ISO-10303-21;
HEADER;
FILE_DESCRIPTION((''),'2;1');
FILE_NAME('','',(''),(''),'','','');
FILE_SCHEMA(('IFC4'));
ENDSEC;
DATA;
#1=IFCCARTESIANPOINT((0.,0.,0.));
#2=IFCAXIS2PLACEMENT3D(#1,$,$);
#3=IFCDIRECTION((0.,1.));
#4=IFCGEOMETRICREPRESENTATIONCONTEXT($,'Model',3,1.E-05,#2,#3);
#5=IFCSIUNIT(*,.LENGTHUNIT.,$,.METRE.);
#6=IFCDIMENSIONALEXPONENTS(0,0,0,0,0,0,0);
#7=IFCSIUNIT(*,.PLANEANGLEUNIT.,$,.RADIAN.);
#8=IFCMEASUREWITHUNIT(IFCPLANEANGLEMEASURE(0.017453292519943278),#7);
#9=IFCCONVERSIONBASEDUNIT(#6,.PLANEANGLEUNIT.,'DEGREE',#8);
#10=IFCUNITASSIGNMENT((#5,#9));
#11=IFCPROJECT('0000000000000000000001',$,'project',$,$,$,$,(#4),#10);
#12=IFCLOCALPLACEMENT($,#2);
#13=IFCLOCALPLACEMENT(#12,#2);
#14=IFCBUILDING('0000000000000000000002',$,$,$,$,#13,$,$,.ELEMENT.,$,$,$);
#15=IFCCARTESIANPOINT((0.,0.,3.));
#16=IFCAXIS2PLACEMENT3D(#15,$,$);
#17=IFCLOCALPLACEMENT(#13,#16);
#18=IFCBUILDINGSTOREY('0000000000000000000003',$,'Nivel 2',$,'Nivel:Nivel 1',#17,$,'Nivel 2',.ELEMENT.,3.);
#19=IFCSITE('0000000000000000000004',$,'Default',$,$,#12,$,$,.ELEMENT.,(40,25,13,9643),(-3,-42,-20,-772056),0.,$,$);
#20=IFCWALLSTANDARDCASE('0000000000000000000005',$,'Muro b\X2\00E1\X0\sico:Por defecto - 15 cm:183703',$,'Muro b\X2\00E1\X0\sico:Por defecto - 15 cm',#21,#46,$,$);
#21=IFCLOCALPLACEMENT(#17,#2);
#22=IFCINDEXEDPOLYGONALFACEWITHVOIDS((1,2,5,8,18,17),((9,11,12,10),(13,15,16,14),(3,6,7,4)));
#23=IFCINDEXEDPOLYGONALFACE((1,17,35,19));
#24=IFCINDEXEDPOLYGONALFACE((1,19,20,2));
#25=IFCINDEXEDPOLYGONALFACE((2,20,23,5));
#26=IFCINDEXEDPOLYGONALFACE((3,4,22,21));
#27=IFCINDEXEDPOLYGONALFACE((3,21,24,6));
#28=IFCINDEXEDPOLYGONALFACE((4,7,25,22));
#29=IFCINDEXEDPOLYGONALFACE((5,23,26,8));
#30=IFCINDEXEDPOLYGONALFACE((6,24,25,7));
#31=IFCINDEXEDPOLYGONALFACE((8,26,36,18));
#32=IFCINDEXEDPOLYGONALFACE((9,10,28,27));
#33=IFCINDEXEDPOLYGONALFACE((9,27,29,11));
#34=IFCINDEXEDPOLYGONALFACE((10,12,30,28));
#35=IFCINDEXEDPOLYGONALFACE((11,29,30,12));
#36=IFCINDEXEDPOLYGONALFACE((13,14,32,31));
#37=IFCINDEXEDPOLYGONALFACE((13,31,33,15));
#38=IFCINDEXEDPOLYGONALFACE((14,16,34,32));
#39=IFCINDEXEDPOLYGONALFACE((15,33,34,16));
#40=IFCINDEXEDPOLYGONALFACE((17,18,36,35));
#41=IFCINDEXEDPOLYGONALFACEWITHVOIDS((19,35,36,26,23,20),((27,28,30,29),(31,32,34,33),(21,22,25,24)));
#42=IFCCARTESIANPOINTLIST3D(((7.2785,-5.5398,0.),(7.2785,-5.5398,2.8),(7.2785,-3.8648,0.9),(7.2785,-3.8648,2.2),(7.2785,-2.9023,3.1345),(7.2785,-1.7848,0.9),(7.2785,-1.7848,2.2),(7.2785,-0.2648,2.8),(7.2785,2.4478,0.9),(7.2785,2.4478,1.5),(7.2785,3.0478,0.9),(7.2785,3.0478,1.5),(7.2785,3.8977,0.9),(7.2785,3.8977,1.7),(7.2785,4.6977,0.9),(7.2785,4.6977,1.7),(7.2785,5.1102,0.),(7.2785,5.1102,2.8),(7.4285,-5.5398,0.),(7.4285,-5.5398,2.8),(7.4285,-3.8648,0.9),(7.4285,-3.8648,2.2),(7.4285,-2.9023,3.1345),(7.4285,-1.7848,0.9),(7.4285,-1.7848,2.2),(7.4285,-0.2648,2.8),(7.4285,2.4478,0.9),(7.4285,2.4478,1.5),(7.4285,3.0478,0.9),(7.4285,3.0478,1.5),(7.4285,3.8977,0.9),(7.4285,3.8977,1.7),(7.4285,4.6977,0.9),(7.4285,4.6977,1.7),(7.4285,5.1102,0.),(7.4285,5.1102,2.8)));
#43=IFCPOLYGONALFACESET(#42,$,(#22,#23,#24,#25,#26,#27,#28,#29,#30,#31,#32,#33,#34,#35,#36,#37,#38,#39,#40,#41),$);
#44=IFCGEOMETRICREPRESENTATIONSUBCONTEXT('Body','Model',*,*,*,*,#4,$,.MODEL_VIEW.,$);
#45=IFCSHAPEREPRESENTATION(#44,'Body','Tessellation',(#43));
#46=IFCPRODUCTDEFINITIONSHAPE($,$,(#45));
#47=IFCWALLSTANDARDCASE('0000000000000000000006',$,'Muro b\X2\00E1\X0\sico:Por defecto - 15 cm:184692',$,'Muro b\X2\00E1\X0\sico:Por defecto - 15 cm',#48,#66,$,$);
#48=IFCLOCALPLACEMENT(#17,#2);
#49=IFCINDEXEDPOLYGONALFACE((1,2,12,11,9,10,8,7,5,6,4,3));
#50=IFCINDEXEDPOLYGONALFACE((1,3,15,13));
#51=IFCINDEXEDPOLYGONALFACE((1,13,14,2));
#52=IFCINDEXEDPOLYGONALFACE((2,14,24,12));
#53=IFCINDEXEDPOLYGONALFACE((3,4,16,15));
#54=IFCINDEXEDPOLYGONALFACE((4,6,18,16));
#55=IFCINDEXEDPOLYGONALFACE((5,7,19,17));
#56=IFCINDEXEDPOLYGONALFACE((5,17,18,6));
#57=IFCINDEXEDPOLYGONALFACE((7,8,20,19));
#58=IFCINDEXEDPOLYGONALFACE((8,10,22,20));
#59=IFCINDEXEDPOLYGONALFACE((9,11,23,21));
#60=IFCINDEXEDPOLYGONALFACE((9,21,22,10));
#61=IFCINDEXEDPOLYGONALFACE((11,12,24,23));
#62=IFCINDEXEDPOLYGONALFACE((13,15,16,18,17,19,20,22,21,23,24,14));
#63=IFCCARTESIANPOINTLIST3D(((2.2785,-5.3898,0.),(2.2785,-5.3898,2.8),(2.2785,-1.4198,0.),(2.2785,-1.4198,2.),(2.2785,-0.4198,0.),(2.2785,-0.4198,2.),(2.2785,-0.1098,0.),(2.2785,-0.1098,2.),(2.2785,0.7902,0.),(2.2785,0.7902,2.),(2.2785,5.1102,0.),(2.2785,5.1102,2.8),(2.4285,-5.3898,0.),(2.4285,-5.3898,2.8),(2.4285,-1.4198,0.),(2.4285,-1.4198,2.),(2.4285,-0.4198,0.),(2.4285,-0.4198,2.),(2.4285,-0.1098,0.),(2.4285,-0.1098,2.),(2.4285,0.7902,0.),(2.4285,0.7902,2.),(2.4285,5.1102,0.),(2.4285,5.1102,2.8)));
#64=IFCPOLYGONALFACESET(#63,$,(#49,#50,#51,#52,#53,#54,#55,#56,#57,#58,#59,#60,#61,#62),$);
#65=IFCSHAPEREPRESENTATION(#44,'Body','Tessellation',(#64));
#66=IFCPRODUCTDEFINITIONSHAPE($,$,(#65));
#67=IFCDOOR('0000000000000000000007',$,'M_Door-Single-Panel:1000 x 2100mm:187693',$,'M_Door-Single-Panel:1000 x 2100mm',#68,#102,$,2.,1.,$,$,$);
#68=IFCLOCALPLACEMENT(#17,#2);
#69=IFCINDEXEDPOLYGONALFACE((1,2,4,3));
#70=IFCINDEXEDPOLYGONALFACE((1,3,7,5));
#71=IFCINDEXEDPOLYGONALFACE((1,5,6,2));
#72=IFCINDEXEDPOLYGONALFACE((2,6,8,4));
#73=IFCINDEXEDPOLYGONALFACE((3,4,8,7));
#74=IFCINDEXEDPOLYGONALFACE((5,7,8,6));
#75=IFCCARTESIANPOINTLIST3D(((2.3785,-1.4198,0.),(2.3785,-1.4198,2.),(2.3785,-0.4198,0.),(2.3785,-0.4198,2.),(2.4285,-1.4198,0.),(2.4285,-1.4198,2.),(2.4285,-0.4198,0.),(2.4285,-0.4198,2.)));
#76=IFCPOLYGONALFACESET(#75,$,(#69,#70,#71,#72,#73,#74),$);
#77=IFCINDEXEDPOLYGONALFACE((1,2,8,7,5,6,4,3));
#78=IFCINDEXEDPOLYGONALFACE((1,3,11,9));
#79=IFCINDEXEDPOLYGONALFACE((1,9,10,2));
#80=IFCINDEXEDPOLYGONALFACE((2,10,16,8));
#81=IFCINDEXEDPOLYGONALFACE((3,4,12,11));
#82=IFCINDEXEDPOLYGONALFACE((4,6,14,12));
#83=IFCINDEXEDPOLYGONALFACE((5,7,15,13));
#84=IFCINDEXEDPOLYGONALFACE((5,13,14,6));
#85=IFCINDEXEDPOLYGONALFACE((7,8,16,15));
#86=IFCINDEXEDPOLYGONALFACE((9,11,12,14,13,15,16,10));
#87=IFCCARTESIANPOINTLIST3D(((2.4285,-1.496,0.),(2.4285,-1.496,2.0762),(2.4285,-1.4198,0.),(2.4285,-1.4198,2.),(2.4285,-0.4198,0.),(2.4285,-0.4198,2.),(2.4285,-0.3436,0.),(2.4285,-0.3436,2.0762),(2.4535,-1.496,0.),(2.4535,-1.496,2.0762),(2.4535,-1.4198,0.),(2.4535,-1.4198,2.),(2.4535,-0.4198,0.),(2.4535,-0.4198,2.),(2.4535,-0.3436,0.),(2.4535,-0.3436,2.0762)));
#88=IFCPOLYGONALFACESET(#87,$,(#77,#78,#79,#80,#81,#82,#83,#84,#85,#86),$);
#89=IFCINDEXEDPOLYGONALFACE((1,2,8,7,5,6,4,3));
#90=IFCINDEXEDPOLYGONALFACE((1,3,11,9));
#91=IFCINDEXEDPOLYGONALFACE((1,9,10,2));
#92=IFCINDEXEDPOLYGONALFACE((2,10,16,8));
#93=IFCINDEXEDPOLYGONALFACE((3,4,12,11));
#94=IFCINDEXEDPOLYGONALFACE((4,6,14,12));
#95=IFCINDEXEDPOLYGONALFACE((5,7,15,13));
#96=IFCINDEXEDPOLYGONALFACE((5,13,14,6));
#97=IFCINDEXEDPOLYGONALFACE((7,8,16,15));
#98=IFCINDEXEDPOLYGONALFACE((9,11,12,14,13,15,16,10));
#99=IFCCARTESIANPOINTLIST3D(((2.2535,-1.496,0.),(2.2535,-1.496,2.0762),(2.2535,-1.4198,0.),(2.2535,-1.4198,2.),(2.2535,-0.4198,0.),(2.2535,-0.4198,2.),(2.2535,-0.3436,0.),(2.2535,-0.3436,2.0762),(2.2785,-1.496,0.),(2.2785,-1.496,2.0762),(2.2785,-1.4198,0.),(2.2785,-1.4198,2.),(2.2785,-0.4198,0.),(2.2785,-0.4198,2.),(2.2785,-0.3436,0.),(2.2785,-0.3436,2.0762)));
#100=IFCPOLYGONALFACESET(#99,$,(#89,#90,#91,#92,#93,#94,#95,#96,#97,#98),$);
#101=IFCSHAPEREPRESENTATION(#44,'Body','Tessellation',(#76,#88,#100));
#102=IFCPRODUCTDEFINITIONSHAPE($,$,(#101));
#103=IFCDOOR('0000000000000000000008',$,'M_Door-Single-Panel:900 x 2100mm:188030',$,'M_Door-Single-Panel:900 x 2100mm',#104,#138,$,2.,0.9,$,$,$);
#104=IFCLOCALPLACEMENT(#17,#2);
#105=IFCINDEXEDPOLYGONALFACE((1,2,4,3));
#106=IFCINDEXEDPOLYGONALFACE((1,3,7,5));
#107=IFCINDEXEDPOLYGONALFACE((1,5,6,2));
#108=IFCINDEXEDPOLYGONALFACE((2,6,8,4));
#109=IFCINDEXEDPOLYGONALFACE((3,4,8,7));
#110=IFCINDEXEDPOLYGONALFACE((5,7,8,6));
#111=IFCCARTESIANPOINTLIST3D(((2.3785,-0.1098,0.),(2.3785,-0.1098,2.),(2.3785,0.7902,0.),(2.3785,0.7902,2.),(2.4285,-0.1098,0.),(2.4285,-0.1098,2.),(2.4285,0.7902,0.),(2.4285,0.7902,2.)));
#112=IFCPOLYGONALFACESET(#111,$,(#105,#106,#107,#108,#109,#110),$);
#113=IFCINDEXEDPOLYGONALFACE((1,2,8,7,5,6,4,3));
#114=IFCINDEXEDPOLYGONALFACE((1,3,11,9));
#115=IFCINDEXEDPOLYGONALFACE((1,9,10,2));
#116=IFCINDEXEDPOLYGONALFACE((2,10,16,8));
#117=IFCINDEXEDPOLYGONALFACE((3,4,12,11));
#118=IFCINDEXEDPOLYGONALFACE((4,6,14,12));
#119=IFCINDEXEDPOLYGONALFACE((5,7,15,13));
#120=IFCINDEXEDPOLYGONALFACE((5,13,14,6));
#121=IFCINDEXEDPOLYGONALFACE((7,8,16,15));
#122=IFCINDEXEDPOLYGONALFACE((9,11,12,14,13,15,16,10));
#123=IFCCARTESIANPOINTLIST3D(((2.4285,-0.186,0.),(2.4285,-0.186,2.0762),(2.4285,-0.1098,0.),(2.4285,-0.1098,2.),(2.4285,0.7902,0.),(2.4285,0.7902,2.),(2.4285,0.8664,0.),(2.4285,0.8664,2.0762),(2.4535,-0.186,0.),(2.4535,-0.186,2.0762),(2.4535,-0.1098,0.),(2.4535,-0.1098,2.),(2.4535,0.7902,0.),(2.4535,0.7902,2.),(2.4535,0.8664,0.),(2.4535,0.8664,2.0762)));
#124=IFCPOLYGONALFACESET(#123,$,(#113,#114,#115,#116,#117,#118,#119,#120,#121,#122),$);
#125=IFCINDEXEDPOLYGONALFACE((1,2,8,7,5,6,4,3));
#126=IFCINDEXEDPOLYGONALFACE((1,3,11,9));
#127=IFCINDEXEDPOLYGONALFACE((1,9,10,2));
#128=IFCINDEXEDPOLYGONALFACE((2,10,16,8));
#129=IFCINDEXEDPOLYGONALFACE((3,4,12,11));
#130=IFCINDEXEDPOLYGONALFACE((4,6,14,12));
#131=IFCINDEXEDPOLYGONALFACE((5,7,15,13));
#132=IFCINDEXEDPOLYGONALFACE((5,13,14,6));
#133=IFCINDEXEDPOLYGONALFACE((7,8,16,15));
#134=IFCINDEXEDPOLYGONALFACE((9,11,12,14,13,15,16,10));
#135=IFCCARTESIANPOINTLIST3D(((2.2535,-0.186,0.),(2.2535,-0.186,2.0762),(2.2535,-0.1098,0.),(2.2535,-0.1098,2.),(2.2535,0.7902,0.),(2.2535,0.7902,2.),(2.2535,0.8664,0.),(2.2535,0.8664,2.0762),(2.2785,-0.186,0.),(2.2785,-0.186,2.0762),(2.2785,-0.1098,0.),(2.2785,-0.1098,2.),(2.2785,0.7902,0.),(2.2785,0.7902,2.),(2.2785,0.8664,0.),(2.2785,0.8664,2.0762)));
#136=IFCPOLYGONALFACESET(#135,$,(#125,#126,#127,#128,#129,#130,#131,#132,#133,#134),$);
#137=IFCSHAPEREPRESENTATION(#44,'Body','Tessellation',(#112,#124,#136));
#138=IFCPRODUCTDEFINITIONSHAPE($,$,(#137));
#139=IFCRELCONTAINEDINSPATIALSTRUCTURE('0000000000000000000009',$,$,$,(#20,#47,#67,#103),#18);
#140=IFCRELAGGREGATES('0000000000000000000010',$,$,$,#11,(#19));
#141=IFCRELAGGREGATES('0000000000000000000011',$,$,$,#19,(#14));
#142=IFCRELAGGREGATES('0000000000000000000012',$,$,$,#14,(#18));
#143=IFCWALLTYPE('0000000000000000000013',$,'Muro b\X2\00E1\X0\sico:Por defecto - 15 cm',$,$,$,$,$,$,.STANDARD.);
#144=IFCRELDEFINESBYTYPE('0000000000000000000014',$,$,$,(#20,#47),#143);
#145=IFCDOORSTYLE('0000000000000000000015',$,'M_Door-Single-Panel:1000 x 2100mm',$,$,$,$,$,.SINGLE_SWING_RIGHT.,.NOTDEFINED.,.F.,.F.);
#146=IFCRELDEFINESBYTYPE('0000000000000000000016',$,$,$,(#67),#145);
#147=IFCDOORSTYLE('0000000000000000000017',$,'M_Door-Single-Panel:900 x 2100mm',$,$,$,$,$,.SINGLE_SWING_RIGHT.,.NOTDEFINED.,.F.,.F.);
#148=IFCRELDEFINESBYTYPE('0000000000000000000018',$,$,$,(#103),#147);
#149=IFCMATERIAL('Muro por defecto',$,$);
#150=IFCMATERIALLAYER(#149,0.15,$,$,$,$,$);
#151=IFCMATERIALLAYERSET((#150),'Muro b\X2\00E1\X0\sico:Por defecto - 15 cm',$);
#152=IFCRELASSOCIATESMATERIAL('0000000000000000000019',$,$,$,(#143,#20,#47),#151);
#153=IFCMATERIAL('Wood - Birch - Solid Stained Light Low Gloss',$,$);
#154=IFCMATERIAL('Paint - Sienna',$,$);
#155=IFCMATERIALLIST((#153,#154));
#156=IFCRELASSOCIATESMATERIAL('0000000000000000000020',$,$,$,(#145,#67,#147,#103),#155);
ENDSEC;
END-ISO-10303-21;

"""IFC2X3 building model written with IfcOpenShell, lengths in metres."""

from ifc_helpers import new_model, entity, si_unit, converted_unit, direction, frame, frame_2d, origin, origin_2d_with_axis, place, context, subcontext, project, spatial, polyline, rectangle, outline, extrude, clip, bounded_halfspace, source, transform, mapped, material, material_list, layer, layer_set, layer_usage, type_object, type_shapes, element, fill, save


model = new_model("IFC2X3")

# Units and contexts
model_context = context("Model", 3, precision=1e-05, world=origin(), true_north=direction((0.0, 1.0)))
body_context = subcontext(model_context, "Body", "Model", "MODEL_VIEW")
ifc_project = project(units=[si_unit("LENGTHUNIT", "METRE"), converted_unit("PLANEANGLEUNIT", "DEGREE", entity("IfcPlaneAngleMeasure", 0.017453292519943278), si_unit("PLANEANGLEUNIT", "RADIAN"), dimensions=[0, 0, 0, 0, 0, 0, 0])], contexts=[model_context])

# Site, building, storey
site_placement = place(None, origin())
site = spatial("IfcSite", under=ifc_project, at=site_placement, Name="Default", CompositionType="ELEMENT", RefLatitude=(40, 25, 13, 9643), RefLongitude=(-3, -42, -20, -772056), RefElevation=0.0)
building_placement = place(site_placement, origin())
building = spatial("IfcBuilding", under=site, at=building_placement, CompositionType="ELEMENT")
storey_placement = place(building_placement, frame((0.0, 0.0, 3.0)))
storey = spatial("IfcBuildingStorey", under=building, at=storey_placement, Name="Nivel 2", ObjectType="Nivel:Nivel 1", LongName="Nivel 2", CompositionType="ELEMENT", Elevation=3.0)

# Wall, openings
ifc_material_1 = material(Name="Muro por defecto")
ifc_layer_1 = layer(ifc_material_1, 0.15)
ifc_layer_set_1 = layer_set([ifc_layer_1], Name="Muro básico:Por defecto - 15 cm")
ifc_layer_usage_1 = layer_usage(ifc_layer_set_1, "AXIS2", "NEGATIVE", 0.075)
wall_type_1 = type_object("IfcWallType", Name="Muro básico:Por defecto - 15 cm", PredefinedType="STANDARD", material=ifc_layer_set_1)
wall_1_placement = place(storey_placement, frame((7.3535, 5.1102, 0.0), z_axis=(0.0, 0.0, 1.0), x_axis=(0.0, -1.0, 0.0)))
wall_1 = element("IfcWallStandardCase", 1, at=wall_1_placement, inside=storey, type_object=wall_type_1, material=ifc_layer_usage_1, Name="Muro básico:Por defecto - 15 cm:183703", ObjectType="Muro básico:Por defecto - 15 cm", context=body_context, shape_type="Clipping", body=[
    clip(clip(clip(clip(extrude(rectangle(XDim=10.65, YDim=0.15, at=frame_2d((5.325, 0.0), x_axis=(-1.0, 0.0))), origin(), (0.0, 0.0, 1.0), 3.1345), bounded_halfspace(frame((0.0, -0.075, 2.8), z_axis=(0.0, 0.0, -1.0), x_axis=(0.0, 1.0, 0.0)), True, frame((0.0, -0.075, 2.8)), polyline([(0.0, 0.0), (0.15, 0.0), (1.475, 0.0), (1.625, 0.0), (2.925, 0.0), (3.075, 0.0), (5.3, 0.0), (5.375, 0.0), (5.375, 0.15), (0.0, 0.15), (0.0, 0.0)]))), bounded_halfspace(frame((5.375, -0.075, 2.8), z_axis=(-0.125829, 0.0, 0.992052), x_axis=(0.0, -1.0, 0.0)), False, frame((5.375, -0.075, 2.8)), polyline([(0.0, 0.0), (2.6375, 0.0), (2.6375, 0.15), (0.0, 0.15), (0.0, 0.0)]))), bounded_halfspace(frame((8.0125, -0.075, 3.1345), z_axis=(0.125829, 0.0, 0.992052), x_axis=(0.0, 1.0, 0.0)), False, frame((8.0125, -0.075, 3.1345)), polyline([(0.0, 0.0), (2.6375, 0.0), (2.6375, 0.15), (0.0, 0.15), (0.0, 0.0)]))), bounded_halfspace(frame((0.0, -0.075, 2.8), z_axis=(0.0, 0.0, -1.0), x_axis=(0.0, 1.0, 0.0)), True, frame((0.0, -0.075, 2.8)), polyline([(0.0, 0.0), (0.15, 0.0), (1.475, 0.0), (1.625, 0.0), (2.925, 0.0), (3.075, 0.0), (5.3, 0.0), (5.375, 0.0), (5.375, 0.15), (0.0, 0.15), (0.0, 0.0)]))),
])
opening_1_placement = place(wall_1_placement, frame((0.4125, -0.075, 0.9)))
element("IfcOpeningElement", 2, at=opening_1_placement, cuts=wall_1, ObjectType="Opening", context=body_context, shape_type="SweptSolid", body=[
    extrude(rectangle(XDim=0.8, YDim=0.8, at=frame_2d((0.4, 0.4), x_axis=(1.0, 0.0))), frame((0.0, 0.0, 0.0), z_axis=(0.0, 1.0, 0.0), x_axis=(0.0, 0.0, 1.0)), (0.0, 0.0, 1.0), 0.15),
])
opening_2_placement = place(wall_1_placement, frame((2.0625, -0.075, 0.9)))
element("IfcOpeningElement", 3, at=opening_2_placement, cuts=wall_1, ObjectType="Opening", context=body_context, shape_type="SweptSolid", body=[
    extrude(rectangle(XDim=0.6, YDim=0.6, at=frame_2d((0.3, 0.3), x_axis=(1.0, 0.0))), frame((0.0, 0.0, 0.0), z_axis=(0.0, 1.0, 0.0), x_axis=(0.0, 0.0, 1.0)), (0.0, 0.0, 1.0), 0.15),
])
opening_3_placement = place(wall_1_placement, frame((6.895, -0.075, 0.9)))
element("IfcOpeningElement", 4, at=opening_3_placement, cuts=wall_1, ObjectType="Opening", context=body_context, shape_type="SweptSolid", body=[
    extrude(rectangle(XDim=1.3, YDim=2.08, at=frame_2d((0.65, 1.04), x_axis=(-1.0, 0.0))), frame((0.0, 0.0, 0.0), z_axis=(0.0, 1.0, 0.0), x_axis=(0.0, 0.0, 1.0)), (0.0, 0.0, 1.0), 0.15),
])

# Wall, openings, doors
ifc_layer_usage_2 = layer_usage(ifc_layer_set_1, "AXIS2", "POSITIVE", -0.075)
wall_2_placement = place(storey_placement, frame((2.3535, -5.3898, 0.0), z_axis=(0.0, 0.0, 1.0), x_axis=(0.0, 1.0, 0.0)))
wall_2 = element("IfcWallStandardCase", 5, at=wall_2_placement, inside=storey, type_object=wall_type_1, material=ifc_layer_usage_2, Name="Muro básico:Por defecto - 15 cm:184692", ObjectType="Muro básico:Por defecto - 15 cm", context=body_context, shape_type="Clipping", body=[
    clip(extrude(rectangle(XDim=10.5, YDim=0.15, at=frame_2d((5.25, 0.0), x_axis=(1.0, 0.0))), origin(), (0.0, 0.0, 1.0), 2.8), bounded_halfspace(frame((0.0, -0.075, 2.8), z_axis=(0.0, 0.0, -1.0), x_axis=(0.0, -1.0, 0.0)), True, frame((0.0, -0.075, 2.8)), polyline([(0.0, 0.0), (5.05, 0.0), (5.125, 0.0), (5.2, 0.0), (8.35, 0.0), (8.5, 0.0), (10.35, 0.0), (10.5, 0.0), (10.5, 0.15), (9.475, 0.15), (9.325, 0.15), (5.2, 0.15), (5.05, 0.15), (0.0, 0.15), (0.0, 0.0)]))),
])
opening_4_placement = place(wall_2_placement, origin())
element("IfcOpeningElement", 6, at=opening_4_placement, cuts=wall_2, ObjectType="Opening", context=body_context, shape_type="SweptSolid", body=[
    extrude(rectangle(XDim=2.0, YDim=0.15, at=frame_2d((0.0, 0.0), x_axis=(0.0, 1.0))), frame((8.425, -0.815, 1.0), z_axis=(0.0, 1.0, 0.0), x_axis=(-1.0, 0.0, 0.0)), (0.0, 0.0, 1.0), 0.7),
])
opening_5_placement = place(wall_2_placement, frame((4.97, 0.075, 0.0)))
opening_5 = element("IfcOpeningElement", 7, at=opening_5_placement, cuts=wall_2, ObjectType="Opening", context=body_context, shape_type="SweptSolid", body=[
    extrude(rectangle(XDim=1.0, YDim=2.0, at=frame_2d((1.0, 0.5), x_axis=(0.0, 1.0))), frame((0.0, 0.0, 0.0), z_axis=(0.0, -1.0, 0.0), x_axis=(0.0, 0.0, 1.0)), (0.0, 0.0, 1.0), 0.15),
])
opening_6_placement = place(wall_2_placement, frame((6.18, 0.075, 0.0)))
opening_6 = element("IfcOpeningElement", 8, at=opening_6_placement, cuts=wall_2, ObjectType="Opening", context=body_context, shape_type="SweptSolid", body=[
    extrude(rectangle(XDim=0.9, YDim=2.0, at=frame_2d((1.0, 0.45), x_axis=(0.0, 1.0))), frame((0.0, 0.0, 0.0), z_axis=(0.0, -1.0, 0.0), x_axis=(0.0, 0.0, 1.0)), (0.0, 0.0, 1.0), 0.15),
])
ifc_material_2 = material(Name="Wood - Birch - Solid Stained Light Low Gloss")
ifc_material_3 = material(Name="Paint - Sienna")
ifc_material_list_1 = material_list([ifc_material_2, ifc_material_3])
door_style_1 = type_object("IfcDoorStyle", Name="M_Door-Single-Panel:1000 x 2100mm", ConstructionType="NOTDEFINED", OperationType="SINGLE_SWING_RIGHT", ParameterTakesPrecedence=False, Sizeable=False, material=ifc_material_list_1)
shared_shape_1 = source(origin(), body_context, "Body", "SweptSolid", [
    extrude(rectangle(XDim=0.05, YDim=1.0, at=origin_2d_with_axis()), frame((0.5, 0.125, 0.0), z_axis=(0.0, 0.0, 1.0), x_axis=(0.0, 1.0, 0.0)), (0.0, 0.0, 1.0), 2.0),
    extrude(outline(polyline([(-0.5762, -1.0571), (0.5762, -1.0571), (0.5762, 1.0191), (0.5, 1.0191), (0.5, -0.981), (-0.5, -0.981), (-0.5, 1.0191), (-0.5762, 1.0191), (-0.5762, -1.0571)])), frame((0.5, 0.15, 1.0191), z_axis=(0.0, 1.0, 0.0), x_axis=(1.0, 0.0, 0.0)), (0.0, 0.0, 1.0), 0.025),
    extrude(outline(polyline([(-1.0571, -0.5762), (1.019, -0.5762), (1.019, -0.5), (-0.9809, -0.5), (-0.9809, 0.5), (1.019, 0.5), (1.019, 0.5762), (-1.0571, 0.5762), (-1.0571, -0.5762)])), frame((0.5, -0.025, 1.019), z_axis=(0.0, 1.0, 0.0), x_axis=(0.0, 0.0, -1.0)), (0.0, 0.0, 1.0), 0.025),
])
type_shapes(door_style_1, [shared_shape_1])
door_1_placement = place(opening_5_placement, frame((0.0, 0.0, 0.0), z_axis=(0.0, 0.0, 1.0), x_axis=(-1.0, 0.0, 0.0)))
door_1 = element("IfcDoor", 9, at=door_1_placement, inside=storey, type_object=door_style_1, material=ifc_material_list_1, Name="M_Door-Single-Panel:1000 x 2100mm:187693", ObjectType="M_Door-Single-Panel:1000 x 2100mm", OverallHeight=2.0, OverallWidth=1.0, context=body_context, shape_type="MappedRepresentation", body=[
    mapped(shared_shape_1, transform((0.0, 0.0, 0.0), scale=1.0)),
])
fill(opening_5, door_1)
door_style_2 = type_object("IfcDoorStyle", Name="M_Door-Single-Panel:900 x 2100mm", ConstructionType="NOTDEFINED", OperationType="SINGLE_SWING_RIGHT", ParameterTakesPrecedence=False, Sizeable=False, material=ifc_material_list_1)
shared_shape_2 = source(origin(), body_context, "Body", "SweptSolid", [
    extrude(rectangle(XDim=0.05, YDim=0.9, at=origin_2d_with_axis()), frame((0.45, 0.125, 0.0), z_axis=(0.0, 0.0, 1.0), x_axis=(0.0, 1.0, 0.0)), (0.0, 0.0, 1.0), 2.0),
    extrude(outline(polyline([(-0.5262, -1.0571), (0.5262, -1.0571), (0.5262, 1.0191), (0.45, 1.0191), (0.45, -0.981), (-0.45, -0.981), (-0.45, 1.0191), (-0.5262, 1.0191), (-0.5262, -1.0571)])), frame((0.45, 0.15, 1.0191), z_axis=(0.0, 1.0, 0.0), x_axis=(1.0, 0.0, 0.0)), (0.0, 0.0, 1.0), 0.025),
    extrude(outline(polyline([(-1.0571, -0.5262), (1.019, -0.5262), (1.019, -0.45), (-0.9809, -0.45), (-0.9809, 0.45), (1.019, 0.45), (1.019, 0.5262), (-1.0571, 0.5262), (-1.0571, -0.5262)])), frame((0.45, -0.025, 1.019), z_axis=(0.0, 1.0, 0.0), x_axis=(0.0, 0.0, -1.0)), (0.0, 0.0, 1.0), 0.025),
])
type_shapes(door_style_2, [shared_shape_2])
door_2_placement = place(opening_6_placement, frame((0.0, 0.0, 0.0), z_axis=(0.0, 0.0, 1.0), x_axis=(-1.0, 0.0, 0.0)))
door_2 = element("IfcDoor", 10, at=door_2_placement, inside=storey, type_object=door_style_2, material=ifc_material_list_1, Name="M_Door-Single-Panel:900 x 2100mm:188030", ObjectType="M_Door-Single-Panel:900 x 2100mm", OverallHeight=2.0, OverallWidth=0.9, context=body_context, shape_type="MappedRepresentation", body=[
    mapped(shared_shape_2, transform((0.0, 0.0, 0.0), scale=1.0)),
])
fill(opening_6, door_2)

save(model, "model.ifc")
